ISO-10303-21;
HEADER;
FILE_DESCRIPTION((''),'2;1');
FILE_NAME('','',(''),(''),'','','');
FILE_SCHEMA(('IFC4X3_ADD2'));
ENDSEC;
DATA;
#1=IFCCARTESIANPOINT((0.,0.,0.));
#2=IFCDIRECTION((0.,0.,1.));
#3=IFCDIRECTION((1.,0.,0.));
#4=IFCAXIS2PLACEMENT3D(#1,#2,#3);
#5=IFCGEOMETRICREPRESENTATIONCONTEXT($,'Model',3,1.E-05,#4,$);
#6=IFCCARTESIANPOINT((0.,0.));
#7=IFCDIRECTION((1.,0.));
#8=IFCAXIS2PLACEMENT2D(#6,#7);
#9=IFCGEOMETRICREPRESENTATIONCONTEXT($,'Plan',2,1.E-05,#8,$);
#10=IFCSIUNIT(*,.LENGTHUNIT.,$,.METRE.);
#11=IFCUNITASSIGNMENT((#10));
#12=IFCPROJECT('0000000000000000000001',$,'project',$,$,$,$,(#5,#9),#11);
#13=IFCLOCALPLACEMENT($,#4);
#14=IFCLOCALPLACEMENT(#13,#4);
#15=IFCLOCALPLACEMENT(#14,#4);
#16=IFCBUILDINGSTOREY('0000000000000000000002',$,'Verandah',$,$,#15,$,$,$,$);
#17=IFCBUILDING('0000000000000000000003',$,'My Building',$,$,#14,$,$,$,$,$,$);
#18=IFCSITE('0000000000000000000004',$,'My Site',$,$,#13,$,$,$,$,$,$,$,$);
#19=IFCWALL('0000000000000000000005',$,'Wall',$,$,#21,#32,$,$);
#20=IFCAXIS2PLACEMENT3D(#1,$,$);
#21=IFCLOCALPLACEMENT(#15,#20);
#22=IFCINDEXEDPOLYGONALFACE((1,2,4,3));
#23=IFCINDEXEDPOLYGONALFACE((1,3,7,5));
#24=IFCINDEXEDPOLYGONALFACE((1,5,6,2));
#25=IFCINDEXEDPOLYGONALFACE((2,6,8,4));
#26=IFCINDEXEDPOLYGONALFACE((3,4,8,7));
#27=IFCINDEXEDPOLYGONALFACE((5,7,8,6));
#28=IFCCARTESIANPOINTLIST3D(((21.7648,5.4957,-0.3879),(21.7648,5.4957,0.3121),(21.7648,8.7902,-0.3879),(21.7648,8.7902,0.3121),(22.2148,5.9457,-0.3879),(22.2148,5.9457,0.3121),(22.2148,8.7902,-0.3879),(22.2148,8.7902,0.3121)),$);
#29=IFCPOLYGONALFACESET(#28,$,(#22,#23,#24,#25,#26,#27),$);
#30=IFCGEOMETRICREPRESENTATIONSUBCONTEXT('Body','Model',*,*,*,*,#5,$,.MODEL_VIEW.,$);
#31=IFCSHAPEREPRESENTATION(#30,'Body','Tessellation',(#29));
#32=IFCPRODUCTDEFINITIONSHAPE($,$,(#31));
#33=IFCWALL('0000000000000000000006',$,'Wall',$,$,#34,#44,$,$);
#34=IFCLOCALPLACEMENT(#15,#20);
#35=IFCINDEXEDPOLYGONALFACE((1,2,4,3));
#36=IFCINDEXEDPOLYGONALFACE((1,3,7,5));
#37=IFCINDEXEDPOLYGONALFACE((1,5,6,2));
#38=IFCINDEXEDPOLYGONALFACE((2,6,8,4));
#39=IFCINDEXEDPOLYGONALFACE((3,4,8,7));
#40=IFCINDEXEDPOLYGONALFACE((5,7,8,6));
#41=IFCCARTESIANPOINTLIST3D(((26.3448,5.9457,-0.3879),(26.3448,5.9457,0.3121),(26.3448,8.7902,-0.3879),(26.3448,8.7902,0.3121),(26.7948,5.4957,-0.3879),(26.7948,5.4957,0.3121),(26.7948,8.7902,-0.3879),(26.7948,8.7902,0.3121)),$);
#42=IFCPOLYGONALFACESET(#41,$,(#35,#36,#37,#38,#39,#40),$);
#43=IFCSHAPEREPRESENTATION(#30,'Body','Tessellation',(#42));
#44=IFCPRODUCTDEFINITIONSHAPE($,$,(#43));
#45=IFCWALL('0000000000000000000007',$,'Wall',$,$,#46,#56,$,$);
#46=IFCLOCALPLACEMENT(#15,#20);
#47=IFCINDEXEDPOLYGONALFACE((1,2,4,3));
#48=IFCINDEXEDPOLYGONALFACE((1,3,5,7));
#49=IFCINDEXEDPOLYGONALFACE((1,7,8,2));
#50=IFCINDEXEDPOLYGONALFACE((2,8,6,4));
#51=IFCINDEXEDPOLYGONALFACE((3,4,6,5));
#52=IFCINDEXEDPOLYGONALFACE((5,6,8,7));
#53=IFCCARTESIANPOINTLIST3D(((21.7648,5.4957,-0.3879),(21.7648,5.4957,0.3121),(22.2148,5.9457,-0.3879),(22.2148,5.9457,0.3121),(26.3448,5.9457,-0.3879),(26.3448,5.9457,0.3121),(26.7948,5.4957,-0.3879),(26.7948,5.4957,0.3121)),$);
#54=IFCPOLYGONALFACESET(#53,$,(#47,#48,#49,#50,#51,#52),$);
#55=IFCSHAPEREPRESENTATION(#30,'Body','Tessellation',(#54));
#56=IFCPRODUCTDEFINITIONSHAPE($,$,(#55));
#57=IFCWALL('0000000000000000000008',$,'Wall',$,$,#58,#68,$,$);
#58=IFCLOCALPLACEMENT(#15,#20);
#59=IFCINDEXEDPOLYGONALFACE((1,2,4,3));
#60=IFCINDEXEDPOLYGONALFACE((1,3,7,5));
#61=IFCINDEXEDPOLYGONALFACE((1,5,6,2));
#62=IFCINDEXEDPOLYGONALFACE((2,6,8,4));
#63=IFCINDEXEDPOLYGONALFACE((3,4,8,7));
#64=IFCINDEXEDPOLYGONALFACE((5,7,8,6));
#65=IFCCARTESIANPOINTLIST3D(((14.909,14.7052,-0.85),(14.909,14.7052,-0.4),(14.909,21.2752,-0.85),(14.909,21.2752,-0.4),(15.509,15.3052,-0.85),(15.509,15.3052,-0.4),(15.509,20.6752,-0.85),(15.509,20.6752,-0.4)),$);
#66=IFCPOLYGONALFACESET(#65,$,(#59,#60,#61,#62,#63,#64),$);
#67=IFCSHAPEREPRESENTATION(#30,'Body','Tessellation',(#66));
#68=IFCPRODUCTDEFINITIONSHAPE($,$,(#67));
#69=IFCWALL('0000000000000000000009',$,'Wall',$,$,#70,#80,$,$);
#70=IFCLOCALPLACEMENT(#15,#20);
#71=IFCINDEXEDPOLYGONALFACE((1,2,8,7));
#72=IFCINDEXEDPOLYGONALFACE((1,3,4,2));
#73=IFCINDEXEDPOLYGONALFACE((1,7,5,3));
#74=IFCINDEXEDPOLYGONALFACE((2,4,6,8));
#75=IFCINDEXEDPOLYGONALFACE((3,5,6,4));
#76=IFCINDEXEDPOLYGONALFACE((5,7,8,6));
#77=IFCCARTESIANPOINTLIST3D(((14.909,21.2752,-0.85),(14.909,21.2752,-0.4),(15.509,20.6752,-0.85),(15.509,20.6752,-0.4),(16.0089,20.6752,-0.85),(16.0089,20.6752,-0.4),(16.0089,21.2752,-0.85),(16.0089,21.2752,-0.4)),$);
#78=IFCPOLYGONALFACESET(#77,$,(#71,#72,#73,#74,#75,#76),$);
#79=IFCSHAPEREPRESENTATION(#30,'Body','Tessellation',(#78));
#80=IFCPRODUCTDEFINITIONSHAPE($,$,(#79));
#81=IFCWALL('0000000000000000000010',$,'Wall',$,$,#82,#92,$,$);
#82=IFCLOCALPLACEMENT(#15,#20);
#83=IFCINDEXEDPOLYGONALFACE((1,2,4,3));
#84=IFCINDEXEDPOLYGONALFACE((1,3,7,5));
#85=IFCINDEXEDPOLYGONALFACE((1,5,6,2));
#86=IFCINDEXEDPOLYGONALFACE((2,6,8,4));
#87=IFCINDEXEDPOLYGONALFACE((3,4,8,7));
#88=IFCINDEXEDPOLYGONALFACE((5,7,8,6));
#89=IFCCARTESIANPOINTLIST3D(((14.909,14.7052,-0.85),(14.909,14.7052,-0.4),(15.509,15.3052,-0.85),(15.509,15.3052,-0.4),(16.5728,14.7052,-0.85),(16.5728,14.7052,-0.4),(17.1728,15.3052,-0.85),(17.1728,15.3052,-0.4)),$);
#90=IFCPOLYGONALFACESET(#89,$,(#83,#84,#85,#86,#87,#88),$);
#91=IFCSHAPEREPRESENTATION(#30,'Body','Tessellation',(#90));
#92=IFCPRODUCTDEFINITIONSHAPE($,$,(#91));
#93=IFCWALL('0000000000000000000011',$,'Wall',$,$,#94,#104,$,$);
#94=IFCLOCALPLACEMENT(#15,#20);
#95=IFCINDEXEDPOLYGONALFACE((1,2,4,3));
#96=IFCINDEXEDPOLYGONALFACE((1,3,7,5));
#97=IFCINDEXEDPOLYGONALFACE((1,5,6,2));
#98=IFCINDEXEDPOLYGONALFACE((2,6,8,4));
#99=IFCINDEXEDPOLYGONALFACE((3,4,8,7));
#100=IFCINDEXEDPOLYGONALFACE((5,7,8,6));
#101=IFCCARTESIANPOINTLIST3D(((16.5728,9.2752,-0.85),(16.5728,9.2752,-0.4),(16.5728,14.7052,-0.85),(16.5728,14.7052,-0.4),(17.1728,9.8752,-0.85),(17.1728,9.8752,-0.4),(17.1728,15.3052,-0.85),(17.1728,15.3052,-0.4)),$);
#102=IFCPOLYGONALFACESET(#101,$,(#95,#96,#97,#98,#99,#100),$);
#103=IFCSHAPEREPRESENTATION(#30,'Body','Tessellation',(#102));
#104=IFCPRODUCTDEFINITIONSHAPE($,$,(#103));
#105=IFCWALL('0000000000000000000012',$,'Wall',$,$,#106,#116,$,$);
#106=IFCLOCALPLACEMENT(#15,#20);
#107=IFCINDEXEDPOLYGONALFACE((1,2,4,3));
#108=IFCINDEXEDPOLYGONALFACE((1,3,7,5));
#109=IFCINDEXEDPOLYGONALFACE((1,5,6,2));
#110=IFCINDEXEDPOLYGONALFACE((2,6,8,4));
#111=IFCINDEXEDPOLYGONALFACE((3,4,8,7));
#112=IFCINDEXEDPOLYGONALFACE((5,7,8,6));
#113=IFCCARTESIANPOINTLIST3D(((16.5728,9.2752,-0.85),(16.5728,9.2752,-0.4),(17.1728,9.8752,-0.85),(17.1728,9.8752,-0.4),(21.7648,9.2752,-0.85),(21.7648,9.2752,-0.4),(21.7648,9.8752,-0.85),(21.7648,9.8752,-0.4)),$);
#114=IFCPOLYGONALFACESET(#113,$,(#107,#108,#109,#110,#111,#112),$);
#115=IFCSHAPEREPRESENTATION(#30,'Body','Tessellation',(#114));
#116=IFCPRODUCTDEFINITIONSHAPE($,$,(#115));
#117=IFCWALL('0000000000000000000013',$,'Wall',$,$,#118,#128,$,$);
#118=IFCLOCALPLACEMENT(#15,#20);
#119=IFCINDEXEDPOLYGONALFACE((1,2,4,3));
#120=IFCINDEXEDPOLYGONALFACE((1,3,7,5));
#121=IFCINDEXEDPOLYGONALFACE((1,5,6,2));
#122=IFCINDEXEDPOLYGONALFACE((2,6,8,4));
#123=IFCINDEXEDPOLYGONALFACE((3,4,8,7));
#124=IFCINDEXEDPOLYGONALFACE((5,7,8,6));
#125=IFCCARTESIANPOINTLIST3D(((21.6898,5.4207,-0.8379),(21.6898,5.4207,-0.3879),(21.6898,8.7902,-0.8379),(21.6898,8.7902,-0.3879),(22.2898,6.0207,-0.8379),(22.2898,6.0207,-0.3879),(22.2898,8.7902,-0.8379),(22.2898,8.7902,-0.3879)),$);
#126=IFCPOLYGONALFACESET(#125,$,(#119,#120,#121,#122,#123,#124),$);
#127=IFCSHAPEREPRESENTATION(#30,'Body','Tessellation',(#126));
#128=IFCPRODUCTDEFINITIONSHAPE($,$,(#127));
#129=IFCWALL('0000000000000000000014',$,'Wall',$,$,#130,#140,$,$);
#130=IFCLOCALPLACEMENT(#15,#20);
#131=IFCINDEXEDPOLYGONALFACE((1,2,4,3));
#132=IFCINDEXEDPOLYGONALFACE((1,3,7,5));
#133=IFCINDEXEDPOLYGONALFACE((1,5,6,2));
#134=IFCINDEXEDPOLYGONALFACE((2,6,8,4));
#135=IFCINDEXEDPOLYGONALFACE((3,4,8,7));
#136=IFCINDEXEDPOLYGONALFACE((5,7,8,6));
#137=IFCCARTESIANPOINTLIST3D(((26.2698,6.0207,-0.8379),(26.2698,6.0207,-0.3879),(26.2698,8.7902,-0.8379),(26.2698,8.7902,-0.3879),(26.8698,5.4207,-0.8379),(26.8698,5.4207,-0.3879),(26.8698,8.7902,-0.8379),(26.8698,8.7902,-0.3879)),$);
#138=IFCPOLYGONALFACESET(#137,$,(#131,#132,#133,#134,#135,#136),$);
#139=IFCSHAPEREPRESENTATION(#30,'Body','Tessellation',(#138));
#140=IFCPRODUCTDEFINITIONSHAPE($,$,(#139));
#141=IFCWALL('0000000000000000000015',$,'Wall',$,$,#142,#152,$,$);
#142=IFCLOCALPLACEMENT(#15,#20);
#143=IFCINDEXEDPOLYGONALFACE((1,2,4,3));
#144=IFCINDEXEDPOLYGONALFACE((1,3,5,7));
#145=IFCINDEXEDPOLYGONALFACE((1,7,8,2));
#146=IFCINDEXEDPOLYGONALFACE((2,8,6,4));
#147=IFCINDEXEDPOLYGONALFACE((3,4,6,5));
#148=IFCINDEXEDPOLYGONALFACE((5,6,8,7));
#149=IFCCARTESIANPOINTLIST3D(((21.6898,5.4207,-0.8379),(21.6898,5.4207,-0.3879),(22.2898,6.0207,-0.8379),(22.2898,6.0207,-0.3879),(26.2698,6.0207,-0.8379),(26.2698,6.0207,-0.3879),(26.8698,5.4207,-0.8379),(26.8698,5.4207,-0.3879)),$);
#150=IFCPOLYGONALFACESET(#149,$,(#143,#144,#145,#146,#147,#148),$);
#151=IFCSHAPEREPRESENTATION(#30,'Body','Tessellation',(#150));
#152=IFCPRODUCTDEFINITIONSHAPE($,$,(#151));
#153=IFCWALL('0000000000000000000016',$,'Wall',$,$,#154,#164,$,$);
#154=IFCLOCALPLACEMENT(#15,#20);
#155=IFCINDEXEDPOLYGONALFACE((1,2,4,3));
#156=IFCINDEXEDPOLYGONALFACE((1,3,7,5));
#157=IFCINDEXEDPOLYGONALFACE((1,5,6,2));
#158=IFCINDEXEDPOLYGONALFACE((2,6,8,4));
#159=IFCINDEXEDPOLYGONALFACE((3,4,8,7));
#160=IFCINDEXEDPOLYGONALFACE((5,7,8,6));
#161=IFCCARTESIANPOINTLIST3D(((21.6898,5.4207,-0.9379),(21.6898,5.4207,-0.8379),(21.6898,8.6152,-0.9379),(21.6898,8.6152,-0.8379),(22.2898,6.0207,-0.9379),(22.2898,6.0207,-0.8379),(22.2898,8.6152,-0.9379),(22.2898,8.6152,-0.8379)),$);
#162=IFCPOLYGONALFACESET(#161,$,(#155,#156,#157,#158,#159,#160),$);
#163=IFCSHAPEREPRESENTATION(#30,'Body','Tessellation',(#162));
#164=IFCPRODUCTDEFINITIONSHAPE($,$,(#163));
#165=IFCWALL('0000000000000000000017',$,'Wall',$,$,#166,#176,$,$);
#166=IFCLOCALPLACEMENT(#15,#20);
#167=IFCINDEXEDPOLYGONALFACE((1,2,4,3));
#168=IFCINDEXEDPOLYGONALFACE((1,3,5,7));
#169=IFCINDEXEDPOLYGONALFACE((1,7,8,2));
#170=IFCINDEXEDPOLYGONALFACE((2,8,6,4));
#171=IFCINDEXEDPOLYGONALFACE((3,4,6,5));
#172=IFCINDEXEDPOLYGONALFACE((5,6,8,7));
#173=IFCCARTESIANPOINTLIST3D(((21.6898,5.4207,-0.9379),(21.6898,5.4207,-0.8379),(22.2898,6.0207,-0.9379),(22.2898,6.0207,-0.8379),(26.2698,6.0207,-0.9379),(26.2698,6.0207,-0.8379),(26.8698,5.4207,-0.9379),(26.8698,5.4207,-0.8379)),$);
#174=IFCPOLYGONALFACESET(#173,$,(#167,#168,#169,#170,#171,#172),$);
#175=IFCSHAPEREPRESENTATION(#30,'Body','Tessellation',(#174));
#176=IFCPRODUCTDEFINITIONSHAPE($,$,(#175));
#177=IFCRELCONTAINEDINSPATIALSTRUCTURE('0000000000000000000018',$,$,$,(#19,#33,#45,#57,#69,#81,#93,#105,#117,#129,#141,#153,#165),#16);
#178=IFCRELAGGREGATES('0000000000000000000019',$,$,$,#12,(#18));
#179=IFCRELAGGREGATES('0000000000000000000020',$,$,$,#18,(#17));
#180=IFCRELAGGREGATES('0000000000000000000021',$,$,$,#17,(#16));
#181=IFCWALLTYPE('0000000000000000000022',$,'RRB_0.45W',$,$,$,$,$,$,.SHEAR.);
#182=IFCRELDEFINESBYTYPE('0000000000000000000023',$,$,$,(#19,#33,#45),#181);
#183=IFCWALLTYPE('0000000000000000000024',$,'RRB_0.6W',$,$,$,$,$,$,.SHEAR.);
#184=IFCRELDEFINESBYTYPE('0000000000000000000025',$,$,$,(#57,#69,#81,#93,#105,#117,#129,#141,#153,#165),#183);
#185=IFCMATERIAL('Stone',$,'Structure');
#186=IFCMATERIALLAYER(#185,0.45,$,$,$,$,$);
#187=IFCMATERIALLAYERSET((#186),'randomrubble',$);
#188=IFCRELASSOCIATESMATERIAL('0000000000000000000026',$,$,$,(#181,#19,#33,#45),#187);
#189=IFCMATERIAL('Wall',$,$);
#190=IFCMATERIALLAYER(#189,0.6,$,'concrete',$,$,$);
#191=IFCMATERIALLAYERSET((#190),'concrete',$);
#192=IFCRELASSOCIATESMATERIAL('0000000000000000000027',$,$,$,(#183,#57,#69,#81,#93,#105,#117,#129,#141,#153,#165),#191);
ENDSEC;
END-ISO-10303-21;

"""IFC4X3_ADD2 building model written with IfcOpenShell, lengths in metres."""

from ifc_helpers import new_model, si_unit, frame, origin_with_axes, origin_2d_with_axis, place, context, subcontext, project, spatial, line, indexed_curve, outline, extrude, material, layer, layer_set, layer_usage, type_object, element, save


model = new_model("IFC4X3_ADD2")

# Units and contexts
model_context = context("Model", 3, precision=1e-05, world=origin_with_axes())
plan_context = context("Plan", 2, precision=1e-05, world=origin_2d_with_axis())
body_context = subcontext(model_context, "Body", "Model", "MODEL_VIEW")
ifc_project = project(units=[si_unit("LENGTHUNIT", "METRE")], contexts=[model_context, plan_context])

# Site, building, storey
site_placement = place(None, origin_with_axes())
site = spatial("IfcSite", under=ifc_project, at=site_placement, Name="My Site")
building_placement = place(site_placement, origin_with_axes())
building = spatial("IfcBuilding", under=site, at=building_placement, Name="My Building")
storey_placement = place(building_placement, origin_with_axes())
storey = spatial("IfcBuildingStorey", under=building, at=storey_placement, Name="Verandah")

# Shared definitions
ifc_material_1 = material(Name="Stone", Category="Structure")

# Walls
ifc_layer_1 = layer(ifc_material_1, 0.45)
ifc_layer_set_1 = layer_set([ifc_layer_1], Name="randomrubble")
wall_type_1 = type_object("IfcWallType", Name="RRB_0.45W", PredefinedType="SHEAR", material=ifc_layer_set_1)
ifc_layer_usage_1 = layer_usage(ifc_layer_set_1, "AXIS2", "POSITIVE", 0.0)
wall_1_placement = place(storey_placement, frame((22.2148, 5.4957, -0.3879), z_axis=(0.0, 0.0, 1.0), x_axis=(0.000001, 1.0, 0.0)))
element("IfcWall", 1, at=wall_1_placement, inside=storey, type_object=wall_type_1, material=ifc_layer_usage_1, Name="Wall", context=body_context, shape_type="SweptSolid", body=[
    extrude(outline(indexed_curve([(0.45, 0.0), (0.0, 0.45), (3.2945, 0.45), (3.2945, 0.0)], segments=[line(1, 2, 3, 4, 1)])), origin_with_axes(), (0.0, 0.0, 1.0), 0.7),
])
ifc_layer_usage_2 = layer_usage(ifc_layer_set_1, "AXIS2", "POSITIVE", 0.0)
wall_2_placement = place(storey_placement, frame((26.7948, 5.4957, -0.3879), z_axis=(0.0, 0.0, 1.0), x_axis=(0.000001, 1.0, 0.0)))
element("IfcWall", 2, at=wall_2_placement, inside=storey, type_object=wall_type_1, material=ifc_layer_usage_2, Name="Wall", context=body_context, shape_type="SweptSolid", body=[
    extrude(outline(indexed_curve([(0.0, 0.0), (0.45, 0.45), (3.2945, 0.45), (3.2945, 0.0)], segments=[line(1, 2, 3, 4, 1)])), origin_with_axes(), (0.0, 0.0, 1.0), 0.7),
])
ifc_layer_usage_3 = layer_usage(ifc_layer_set_1, "AXIS2", "POSITIVE", 0.0)
wall_3_placement = place(storey_placement, frame((22.2148, 5.4957, -0.3879), z_axis=(0.0, 0.0, 1.0), x_axis=(1.0, 0.0, 0.0)))
element("IfcWall", 3, at=wall_3_placement, inside=storey, type_object=wall_type_1, material=ifc_layer_usage_3, Name="Wall", context=body_context, shape_type="SweptSolid", body=[
    extrude(outline(indexed_curve([(-0.45, 0.0), (0.0, 0.45), (4.13, 0.45), (4.58, 0.0)], segments=[line(1, 2, 3, 4, 1)])), origin_with_axes(), (0.0, 0.0, 1.0), 0.7),
])
ifc_material_2 = material(Name="Wall")
ifc_layer_2 = layer(ifc_material_2, 0.6, Name="concrete")
ifc_layer_set_2 = layer_set([ifc_layer_2], Name="concrete")
ifc_layer_usage_4 = layer_usage(ifc_layer_set_2, "AXIS2", "POSITIVE", 0.0)
wall_type_2 = type_object("IfcWallType", Name="RRB_0.6W", PredefinedType="SHEAR", material=ifc_layer_set_2)
wall_4_placement = place(storey_placement, frame((15.509, 14.7052, -0.85), z_axis=(0.0, 0.0, 1.0), x_axis=(0.000001, 1.0, 0.0)))
element("IfcWall", 4, at=wall_4_placement, inside=storey, type_object=wall_type_2, material=ifc_layer_usage_4, Name="Wall", context=body_context, shape_type="SweptSolid", body=[
    extrude(outline(indexed_curve([(0.6, 0.0), (0.0, 0.6), (6.57, 0.6), (5.97, 0.0)], segments=[line(1, 2, 3, 4, 1)])), origin_with_axes(), (0.0, 0.0, 1.0), 0.45),
])
ifc_layer_usage_5 = layer_usage(ifc_layer_set_2, "AXIS2", "POSITIVE", 0.0)
wall_5_placement = place(storey_placement, frame((15.509, 20.6752, -0.85), z_axis=(0.0, 0.0, 1.0), x_axis=(1.0, 0.0, 0.0)))
element("IfcWall", 5, at=wall_5_placement, inside=storey, type_object=wall_type_2, material=ifc_layer_usage_5, Name="Wall", context=body_context, shape_type="SweptSolid", body=[
    extrude(outline(indexed_curve([(0.0, 0.0), (-0.6, 0.6), (0.4999, 0.6), (0.4999, 0.0)], segments=[line(1, 2, 3, 4, 1)])), origin_with_axes(), (0.0, 0.0, 1.0), 0.45),
])
ifc_layer_usage_6 = layer_usage(ifc_layer_set_2, "AXIS2", "POSITIVE", 0.0)
wall_6_placement = place(storey_placement, frame((15.509, 14.7052, -0.85), z_axis=(0.0, 0.0, 1.0), x_axis=(1.0, 0.0, 0.0)))
element("IfcWall", 6, at=wall_6_placement, inside=storey, type_object=wall_type_2, material=ifc_layer_usage_6, Name="Wall", context=body_context, shape_type="SweptSolid", body=[
    extrude(outline(indexed_curve([(-0.6, 0.0), (0.0, 0.6), (1.6638, 0.6), (1.0638, 0.0)], segments=[line(1, 2, 3, 4, 1)])), origin_with_axes(), (0.0, 0.0, 1.0), 0.45),
])
ifc_layer_usage_7 = layer_usage(ifc_layer_set_2, "AXIS2", "POSITIVE", 0.0)
wall_7_placement = place(storey_placement, frame((17.1728, 9.2752, -0.85), z_axis=(0.0, 0.0, 1.0), x_axis=(0.000001, 1.0, 0.0)))
element("IfcWall", 7, at=wall_7_placement, inside=storey, type_object=wall_type_2, material=ifc_layer_usage_7, Name="Wall", context=body_context, shape_type="SweptSolid", body=[
    extrude(outline(indexed_curve([(0.6, 0.0), (0.0, 0.6), (5.43, 0.6), (6.03, 0.0)], segments=[line(1, 2, 3, 4, 1)])), origin_with_axes(), (0.0, 0.0, 1.0), 0.45),
])
ifc_layer_usage_8 = layer_usage(ifc_layer_set_2, "AXIS2", "POSITIVE", 0.0)
wall_8_placement = place(storey_placement, frame((17.1728, 9.2752, -0.85), z_axis=(0.0, 0.0, 1.0), x_axis=(1.0, 0.0, 0.0)))
element("IfcWall", 8, at=wall_8_placement, inside=storey, type_object=wall_type_2, material=ifc_layer_usage_8, Name="Wall", context=body_context, shape_type="SweptSolid", body=[
    extrude(outline(indexed_curve([(-0.6, 0.0), (0.0, 0.6), (4.592, 0.6), (4.592, 0.0)], segments=[line(1, 2, 3, 4, 1)])), origin_with_axes(), (0.0, 0.0, 1.0), 0.45),
])
ifc_layer_usage_9 = layer_usage(ifc_layer_set_2, "AXIS2", "POSITIVE", 0.0)
wall_9_placement = place(storey_placement, frame((22.2898, 5.4207, -0.8379), z_axis=(0.0, 0.0, 1.0), x_axis=(0.000001, 1.0, 0.0)))
element("IfcWall", 9, at=wall_9_placement, inside=storey, type_object=wall_type_2, material=ifc_layer_usage_9, Name="Wall", context=body_context, shape_type="SweptSolid", body=[
    extrude(outline(indexed_curve([(0.6, 0.0), (0.0, 0.6), (3.3695, 0.6), (3.3695, 0.0)], segments=[line(1, 2, 3, 4, 1)])), origin_with_axes(), (0.0, 0.0, 1.0), 0.45),
])
ifc_layer_usage_10 = layer_usage(ifc_layer_set_2, "AXIS2", "POSITIVE", 0.0)
wall_10_placement = place(storey_placement, frame((26.8698, 5.4207, -0.8379), z_axis=(0.0, 0.0, 1.0), x_axis=(0.000001, 1.0, 0.0)))
element("IfcWall", 10, at=wall_10_placement, inside=storey, type_object=wall_type_2, material=ifc_layer_usage_10, Name="Wall", context=body_context, shape_type="SweptSolid", body=[
    extrude(outline(indexed_curve([(0.0, 0.0), (0.6, 0.6), (3.3695, 0.6), (3.3695, 0.0)], segments=[line(1, 2, 3, 4, 1)])), origin_with_axes(), (0.0, 0.0, 1.0), 0.45),
])
ifc_layer_usage_11 = layer_usage(ifc_layer_set_2, "AXIS2", "POSITIVE", 0.0)
wall_11_placement = place(storey_placement, frame((22.2898, 5.4207, -0.8379), z_axis=(0.0, 0.0, 1.0), x_axis=(1.0, 0.0, 0.0)))
element("IfcWall", 11, at=wall_11_placement, inside=storey, type_object=wall_type_2, material=ifc_layer_usage_11, Name="Wall", context=body_context, shape_type="SweptSolid", body=[
    extrude(outline(indexed_curve([(-0.6, 0.0), (0.0, 0.6), (3.98, 0.6), (4.58, 0.0)], segments=[line(1, 2, 3, 4, 1)])), origin_with_axes(), (0.0, 0.0, 1.0), 0.45),
])
ifc_layer_usage_12 = layer_usage(ifc_layer_set_2, "AXIS2", "POSITIVE", 0.0)
wall_12_placement = place(storey_placement, frame((22.2898, 6.0207, -0.9379), z_axis=(0.0, 0.0, 1.0), x_axis=(0.000001, 1.0, 0.0)))
element("IfcWall", 12, at=wall_12_placement, inside=storey, type_object=wall_type_2, material=ifc_layer_usage_12, Name="Wall", context=body_context, shape_type="SweptSolid", body=[
    extrude(outline(indexed_curve([(0.0, 0.0), (-0.6, 0.6), (2.5944, 0.6), (2.5944, 0.0)], segments=[line(1, 2, 3, 4, 1)])), origin_with_axes(), (0.0, 0.0, 1.0), 0.1),
])
ifc_layer_usage_13 = layer_usage(ifc_layer_set_2, "AXIS2", "POSITIVE", 0.0)
wall_13_placement = place(storey_placement, frame((26.8698, 6.0207, -0.9379), z_axis=(0.0, 0.0, 1.0), x_axis=(-1.0, 0.000001, 0.0)))
element("IfcWall", 13, at=wall_13_placement, inside=storey, type_object=wall_type_2, material=ifc_layer_usage_13, Name="Wall", context=body_context, shape_type="SweptSolid", body=[
    extrude(outline(indexed_curve([(0.6, 0.0), (0.0, 0.6), (5.18, 0.6), (4.58, 0.0)], segments=[line(1, 2, 3, 4, 1)])), origin_with_axes(), (0.0, 0.0, 1.0), 0.1),
])

save(model, "model.ifc")
